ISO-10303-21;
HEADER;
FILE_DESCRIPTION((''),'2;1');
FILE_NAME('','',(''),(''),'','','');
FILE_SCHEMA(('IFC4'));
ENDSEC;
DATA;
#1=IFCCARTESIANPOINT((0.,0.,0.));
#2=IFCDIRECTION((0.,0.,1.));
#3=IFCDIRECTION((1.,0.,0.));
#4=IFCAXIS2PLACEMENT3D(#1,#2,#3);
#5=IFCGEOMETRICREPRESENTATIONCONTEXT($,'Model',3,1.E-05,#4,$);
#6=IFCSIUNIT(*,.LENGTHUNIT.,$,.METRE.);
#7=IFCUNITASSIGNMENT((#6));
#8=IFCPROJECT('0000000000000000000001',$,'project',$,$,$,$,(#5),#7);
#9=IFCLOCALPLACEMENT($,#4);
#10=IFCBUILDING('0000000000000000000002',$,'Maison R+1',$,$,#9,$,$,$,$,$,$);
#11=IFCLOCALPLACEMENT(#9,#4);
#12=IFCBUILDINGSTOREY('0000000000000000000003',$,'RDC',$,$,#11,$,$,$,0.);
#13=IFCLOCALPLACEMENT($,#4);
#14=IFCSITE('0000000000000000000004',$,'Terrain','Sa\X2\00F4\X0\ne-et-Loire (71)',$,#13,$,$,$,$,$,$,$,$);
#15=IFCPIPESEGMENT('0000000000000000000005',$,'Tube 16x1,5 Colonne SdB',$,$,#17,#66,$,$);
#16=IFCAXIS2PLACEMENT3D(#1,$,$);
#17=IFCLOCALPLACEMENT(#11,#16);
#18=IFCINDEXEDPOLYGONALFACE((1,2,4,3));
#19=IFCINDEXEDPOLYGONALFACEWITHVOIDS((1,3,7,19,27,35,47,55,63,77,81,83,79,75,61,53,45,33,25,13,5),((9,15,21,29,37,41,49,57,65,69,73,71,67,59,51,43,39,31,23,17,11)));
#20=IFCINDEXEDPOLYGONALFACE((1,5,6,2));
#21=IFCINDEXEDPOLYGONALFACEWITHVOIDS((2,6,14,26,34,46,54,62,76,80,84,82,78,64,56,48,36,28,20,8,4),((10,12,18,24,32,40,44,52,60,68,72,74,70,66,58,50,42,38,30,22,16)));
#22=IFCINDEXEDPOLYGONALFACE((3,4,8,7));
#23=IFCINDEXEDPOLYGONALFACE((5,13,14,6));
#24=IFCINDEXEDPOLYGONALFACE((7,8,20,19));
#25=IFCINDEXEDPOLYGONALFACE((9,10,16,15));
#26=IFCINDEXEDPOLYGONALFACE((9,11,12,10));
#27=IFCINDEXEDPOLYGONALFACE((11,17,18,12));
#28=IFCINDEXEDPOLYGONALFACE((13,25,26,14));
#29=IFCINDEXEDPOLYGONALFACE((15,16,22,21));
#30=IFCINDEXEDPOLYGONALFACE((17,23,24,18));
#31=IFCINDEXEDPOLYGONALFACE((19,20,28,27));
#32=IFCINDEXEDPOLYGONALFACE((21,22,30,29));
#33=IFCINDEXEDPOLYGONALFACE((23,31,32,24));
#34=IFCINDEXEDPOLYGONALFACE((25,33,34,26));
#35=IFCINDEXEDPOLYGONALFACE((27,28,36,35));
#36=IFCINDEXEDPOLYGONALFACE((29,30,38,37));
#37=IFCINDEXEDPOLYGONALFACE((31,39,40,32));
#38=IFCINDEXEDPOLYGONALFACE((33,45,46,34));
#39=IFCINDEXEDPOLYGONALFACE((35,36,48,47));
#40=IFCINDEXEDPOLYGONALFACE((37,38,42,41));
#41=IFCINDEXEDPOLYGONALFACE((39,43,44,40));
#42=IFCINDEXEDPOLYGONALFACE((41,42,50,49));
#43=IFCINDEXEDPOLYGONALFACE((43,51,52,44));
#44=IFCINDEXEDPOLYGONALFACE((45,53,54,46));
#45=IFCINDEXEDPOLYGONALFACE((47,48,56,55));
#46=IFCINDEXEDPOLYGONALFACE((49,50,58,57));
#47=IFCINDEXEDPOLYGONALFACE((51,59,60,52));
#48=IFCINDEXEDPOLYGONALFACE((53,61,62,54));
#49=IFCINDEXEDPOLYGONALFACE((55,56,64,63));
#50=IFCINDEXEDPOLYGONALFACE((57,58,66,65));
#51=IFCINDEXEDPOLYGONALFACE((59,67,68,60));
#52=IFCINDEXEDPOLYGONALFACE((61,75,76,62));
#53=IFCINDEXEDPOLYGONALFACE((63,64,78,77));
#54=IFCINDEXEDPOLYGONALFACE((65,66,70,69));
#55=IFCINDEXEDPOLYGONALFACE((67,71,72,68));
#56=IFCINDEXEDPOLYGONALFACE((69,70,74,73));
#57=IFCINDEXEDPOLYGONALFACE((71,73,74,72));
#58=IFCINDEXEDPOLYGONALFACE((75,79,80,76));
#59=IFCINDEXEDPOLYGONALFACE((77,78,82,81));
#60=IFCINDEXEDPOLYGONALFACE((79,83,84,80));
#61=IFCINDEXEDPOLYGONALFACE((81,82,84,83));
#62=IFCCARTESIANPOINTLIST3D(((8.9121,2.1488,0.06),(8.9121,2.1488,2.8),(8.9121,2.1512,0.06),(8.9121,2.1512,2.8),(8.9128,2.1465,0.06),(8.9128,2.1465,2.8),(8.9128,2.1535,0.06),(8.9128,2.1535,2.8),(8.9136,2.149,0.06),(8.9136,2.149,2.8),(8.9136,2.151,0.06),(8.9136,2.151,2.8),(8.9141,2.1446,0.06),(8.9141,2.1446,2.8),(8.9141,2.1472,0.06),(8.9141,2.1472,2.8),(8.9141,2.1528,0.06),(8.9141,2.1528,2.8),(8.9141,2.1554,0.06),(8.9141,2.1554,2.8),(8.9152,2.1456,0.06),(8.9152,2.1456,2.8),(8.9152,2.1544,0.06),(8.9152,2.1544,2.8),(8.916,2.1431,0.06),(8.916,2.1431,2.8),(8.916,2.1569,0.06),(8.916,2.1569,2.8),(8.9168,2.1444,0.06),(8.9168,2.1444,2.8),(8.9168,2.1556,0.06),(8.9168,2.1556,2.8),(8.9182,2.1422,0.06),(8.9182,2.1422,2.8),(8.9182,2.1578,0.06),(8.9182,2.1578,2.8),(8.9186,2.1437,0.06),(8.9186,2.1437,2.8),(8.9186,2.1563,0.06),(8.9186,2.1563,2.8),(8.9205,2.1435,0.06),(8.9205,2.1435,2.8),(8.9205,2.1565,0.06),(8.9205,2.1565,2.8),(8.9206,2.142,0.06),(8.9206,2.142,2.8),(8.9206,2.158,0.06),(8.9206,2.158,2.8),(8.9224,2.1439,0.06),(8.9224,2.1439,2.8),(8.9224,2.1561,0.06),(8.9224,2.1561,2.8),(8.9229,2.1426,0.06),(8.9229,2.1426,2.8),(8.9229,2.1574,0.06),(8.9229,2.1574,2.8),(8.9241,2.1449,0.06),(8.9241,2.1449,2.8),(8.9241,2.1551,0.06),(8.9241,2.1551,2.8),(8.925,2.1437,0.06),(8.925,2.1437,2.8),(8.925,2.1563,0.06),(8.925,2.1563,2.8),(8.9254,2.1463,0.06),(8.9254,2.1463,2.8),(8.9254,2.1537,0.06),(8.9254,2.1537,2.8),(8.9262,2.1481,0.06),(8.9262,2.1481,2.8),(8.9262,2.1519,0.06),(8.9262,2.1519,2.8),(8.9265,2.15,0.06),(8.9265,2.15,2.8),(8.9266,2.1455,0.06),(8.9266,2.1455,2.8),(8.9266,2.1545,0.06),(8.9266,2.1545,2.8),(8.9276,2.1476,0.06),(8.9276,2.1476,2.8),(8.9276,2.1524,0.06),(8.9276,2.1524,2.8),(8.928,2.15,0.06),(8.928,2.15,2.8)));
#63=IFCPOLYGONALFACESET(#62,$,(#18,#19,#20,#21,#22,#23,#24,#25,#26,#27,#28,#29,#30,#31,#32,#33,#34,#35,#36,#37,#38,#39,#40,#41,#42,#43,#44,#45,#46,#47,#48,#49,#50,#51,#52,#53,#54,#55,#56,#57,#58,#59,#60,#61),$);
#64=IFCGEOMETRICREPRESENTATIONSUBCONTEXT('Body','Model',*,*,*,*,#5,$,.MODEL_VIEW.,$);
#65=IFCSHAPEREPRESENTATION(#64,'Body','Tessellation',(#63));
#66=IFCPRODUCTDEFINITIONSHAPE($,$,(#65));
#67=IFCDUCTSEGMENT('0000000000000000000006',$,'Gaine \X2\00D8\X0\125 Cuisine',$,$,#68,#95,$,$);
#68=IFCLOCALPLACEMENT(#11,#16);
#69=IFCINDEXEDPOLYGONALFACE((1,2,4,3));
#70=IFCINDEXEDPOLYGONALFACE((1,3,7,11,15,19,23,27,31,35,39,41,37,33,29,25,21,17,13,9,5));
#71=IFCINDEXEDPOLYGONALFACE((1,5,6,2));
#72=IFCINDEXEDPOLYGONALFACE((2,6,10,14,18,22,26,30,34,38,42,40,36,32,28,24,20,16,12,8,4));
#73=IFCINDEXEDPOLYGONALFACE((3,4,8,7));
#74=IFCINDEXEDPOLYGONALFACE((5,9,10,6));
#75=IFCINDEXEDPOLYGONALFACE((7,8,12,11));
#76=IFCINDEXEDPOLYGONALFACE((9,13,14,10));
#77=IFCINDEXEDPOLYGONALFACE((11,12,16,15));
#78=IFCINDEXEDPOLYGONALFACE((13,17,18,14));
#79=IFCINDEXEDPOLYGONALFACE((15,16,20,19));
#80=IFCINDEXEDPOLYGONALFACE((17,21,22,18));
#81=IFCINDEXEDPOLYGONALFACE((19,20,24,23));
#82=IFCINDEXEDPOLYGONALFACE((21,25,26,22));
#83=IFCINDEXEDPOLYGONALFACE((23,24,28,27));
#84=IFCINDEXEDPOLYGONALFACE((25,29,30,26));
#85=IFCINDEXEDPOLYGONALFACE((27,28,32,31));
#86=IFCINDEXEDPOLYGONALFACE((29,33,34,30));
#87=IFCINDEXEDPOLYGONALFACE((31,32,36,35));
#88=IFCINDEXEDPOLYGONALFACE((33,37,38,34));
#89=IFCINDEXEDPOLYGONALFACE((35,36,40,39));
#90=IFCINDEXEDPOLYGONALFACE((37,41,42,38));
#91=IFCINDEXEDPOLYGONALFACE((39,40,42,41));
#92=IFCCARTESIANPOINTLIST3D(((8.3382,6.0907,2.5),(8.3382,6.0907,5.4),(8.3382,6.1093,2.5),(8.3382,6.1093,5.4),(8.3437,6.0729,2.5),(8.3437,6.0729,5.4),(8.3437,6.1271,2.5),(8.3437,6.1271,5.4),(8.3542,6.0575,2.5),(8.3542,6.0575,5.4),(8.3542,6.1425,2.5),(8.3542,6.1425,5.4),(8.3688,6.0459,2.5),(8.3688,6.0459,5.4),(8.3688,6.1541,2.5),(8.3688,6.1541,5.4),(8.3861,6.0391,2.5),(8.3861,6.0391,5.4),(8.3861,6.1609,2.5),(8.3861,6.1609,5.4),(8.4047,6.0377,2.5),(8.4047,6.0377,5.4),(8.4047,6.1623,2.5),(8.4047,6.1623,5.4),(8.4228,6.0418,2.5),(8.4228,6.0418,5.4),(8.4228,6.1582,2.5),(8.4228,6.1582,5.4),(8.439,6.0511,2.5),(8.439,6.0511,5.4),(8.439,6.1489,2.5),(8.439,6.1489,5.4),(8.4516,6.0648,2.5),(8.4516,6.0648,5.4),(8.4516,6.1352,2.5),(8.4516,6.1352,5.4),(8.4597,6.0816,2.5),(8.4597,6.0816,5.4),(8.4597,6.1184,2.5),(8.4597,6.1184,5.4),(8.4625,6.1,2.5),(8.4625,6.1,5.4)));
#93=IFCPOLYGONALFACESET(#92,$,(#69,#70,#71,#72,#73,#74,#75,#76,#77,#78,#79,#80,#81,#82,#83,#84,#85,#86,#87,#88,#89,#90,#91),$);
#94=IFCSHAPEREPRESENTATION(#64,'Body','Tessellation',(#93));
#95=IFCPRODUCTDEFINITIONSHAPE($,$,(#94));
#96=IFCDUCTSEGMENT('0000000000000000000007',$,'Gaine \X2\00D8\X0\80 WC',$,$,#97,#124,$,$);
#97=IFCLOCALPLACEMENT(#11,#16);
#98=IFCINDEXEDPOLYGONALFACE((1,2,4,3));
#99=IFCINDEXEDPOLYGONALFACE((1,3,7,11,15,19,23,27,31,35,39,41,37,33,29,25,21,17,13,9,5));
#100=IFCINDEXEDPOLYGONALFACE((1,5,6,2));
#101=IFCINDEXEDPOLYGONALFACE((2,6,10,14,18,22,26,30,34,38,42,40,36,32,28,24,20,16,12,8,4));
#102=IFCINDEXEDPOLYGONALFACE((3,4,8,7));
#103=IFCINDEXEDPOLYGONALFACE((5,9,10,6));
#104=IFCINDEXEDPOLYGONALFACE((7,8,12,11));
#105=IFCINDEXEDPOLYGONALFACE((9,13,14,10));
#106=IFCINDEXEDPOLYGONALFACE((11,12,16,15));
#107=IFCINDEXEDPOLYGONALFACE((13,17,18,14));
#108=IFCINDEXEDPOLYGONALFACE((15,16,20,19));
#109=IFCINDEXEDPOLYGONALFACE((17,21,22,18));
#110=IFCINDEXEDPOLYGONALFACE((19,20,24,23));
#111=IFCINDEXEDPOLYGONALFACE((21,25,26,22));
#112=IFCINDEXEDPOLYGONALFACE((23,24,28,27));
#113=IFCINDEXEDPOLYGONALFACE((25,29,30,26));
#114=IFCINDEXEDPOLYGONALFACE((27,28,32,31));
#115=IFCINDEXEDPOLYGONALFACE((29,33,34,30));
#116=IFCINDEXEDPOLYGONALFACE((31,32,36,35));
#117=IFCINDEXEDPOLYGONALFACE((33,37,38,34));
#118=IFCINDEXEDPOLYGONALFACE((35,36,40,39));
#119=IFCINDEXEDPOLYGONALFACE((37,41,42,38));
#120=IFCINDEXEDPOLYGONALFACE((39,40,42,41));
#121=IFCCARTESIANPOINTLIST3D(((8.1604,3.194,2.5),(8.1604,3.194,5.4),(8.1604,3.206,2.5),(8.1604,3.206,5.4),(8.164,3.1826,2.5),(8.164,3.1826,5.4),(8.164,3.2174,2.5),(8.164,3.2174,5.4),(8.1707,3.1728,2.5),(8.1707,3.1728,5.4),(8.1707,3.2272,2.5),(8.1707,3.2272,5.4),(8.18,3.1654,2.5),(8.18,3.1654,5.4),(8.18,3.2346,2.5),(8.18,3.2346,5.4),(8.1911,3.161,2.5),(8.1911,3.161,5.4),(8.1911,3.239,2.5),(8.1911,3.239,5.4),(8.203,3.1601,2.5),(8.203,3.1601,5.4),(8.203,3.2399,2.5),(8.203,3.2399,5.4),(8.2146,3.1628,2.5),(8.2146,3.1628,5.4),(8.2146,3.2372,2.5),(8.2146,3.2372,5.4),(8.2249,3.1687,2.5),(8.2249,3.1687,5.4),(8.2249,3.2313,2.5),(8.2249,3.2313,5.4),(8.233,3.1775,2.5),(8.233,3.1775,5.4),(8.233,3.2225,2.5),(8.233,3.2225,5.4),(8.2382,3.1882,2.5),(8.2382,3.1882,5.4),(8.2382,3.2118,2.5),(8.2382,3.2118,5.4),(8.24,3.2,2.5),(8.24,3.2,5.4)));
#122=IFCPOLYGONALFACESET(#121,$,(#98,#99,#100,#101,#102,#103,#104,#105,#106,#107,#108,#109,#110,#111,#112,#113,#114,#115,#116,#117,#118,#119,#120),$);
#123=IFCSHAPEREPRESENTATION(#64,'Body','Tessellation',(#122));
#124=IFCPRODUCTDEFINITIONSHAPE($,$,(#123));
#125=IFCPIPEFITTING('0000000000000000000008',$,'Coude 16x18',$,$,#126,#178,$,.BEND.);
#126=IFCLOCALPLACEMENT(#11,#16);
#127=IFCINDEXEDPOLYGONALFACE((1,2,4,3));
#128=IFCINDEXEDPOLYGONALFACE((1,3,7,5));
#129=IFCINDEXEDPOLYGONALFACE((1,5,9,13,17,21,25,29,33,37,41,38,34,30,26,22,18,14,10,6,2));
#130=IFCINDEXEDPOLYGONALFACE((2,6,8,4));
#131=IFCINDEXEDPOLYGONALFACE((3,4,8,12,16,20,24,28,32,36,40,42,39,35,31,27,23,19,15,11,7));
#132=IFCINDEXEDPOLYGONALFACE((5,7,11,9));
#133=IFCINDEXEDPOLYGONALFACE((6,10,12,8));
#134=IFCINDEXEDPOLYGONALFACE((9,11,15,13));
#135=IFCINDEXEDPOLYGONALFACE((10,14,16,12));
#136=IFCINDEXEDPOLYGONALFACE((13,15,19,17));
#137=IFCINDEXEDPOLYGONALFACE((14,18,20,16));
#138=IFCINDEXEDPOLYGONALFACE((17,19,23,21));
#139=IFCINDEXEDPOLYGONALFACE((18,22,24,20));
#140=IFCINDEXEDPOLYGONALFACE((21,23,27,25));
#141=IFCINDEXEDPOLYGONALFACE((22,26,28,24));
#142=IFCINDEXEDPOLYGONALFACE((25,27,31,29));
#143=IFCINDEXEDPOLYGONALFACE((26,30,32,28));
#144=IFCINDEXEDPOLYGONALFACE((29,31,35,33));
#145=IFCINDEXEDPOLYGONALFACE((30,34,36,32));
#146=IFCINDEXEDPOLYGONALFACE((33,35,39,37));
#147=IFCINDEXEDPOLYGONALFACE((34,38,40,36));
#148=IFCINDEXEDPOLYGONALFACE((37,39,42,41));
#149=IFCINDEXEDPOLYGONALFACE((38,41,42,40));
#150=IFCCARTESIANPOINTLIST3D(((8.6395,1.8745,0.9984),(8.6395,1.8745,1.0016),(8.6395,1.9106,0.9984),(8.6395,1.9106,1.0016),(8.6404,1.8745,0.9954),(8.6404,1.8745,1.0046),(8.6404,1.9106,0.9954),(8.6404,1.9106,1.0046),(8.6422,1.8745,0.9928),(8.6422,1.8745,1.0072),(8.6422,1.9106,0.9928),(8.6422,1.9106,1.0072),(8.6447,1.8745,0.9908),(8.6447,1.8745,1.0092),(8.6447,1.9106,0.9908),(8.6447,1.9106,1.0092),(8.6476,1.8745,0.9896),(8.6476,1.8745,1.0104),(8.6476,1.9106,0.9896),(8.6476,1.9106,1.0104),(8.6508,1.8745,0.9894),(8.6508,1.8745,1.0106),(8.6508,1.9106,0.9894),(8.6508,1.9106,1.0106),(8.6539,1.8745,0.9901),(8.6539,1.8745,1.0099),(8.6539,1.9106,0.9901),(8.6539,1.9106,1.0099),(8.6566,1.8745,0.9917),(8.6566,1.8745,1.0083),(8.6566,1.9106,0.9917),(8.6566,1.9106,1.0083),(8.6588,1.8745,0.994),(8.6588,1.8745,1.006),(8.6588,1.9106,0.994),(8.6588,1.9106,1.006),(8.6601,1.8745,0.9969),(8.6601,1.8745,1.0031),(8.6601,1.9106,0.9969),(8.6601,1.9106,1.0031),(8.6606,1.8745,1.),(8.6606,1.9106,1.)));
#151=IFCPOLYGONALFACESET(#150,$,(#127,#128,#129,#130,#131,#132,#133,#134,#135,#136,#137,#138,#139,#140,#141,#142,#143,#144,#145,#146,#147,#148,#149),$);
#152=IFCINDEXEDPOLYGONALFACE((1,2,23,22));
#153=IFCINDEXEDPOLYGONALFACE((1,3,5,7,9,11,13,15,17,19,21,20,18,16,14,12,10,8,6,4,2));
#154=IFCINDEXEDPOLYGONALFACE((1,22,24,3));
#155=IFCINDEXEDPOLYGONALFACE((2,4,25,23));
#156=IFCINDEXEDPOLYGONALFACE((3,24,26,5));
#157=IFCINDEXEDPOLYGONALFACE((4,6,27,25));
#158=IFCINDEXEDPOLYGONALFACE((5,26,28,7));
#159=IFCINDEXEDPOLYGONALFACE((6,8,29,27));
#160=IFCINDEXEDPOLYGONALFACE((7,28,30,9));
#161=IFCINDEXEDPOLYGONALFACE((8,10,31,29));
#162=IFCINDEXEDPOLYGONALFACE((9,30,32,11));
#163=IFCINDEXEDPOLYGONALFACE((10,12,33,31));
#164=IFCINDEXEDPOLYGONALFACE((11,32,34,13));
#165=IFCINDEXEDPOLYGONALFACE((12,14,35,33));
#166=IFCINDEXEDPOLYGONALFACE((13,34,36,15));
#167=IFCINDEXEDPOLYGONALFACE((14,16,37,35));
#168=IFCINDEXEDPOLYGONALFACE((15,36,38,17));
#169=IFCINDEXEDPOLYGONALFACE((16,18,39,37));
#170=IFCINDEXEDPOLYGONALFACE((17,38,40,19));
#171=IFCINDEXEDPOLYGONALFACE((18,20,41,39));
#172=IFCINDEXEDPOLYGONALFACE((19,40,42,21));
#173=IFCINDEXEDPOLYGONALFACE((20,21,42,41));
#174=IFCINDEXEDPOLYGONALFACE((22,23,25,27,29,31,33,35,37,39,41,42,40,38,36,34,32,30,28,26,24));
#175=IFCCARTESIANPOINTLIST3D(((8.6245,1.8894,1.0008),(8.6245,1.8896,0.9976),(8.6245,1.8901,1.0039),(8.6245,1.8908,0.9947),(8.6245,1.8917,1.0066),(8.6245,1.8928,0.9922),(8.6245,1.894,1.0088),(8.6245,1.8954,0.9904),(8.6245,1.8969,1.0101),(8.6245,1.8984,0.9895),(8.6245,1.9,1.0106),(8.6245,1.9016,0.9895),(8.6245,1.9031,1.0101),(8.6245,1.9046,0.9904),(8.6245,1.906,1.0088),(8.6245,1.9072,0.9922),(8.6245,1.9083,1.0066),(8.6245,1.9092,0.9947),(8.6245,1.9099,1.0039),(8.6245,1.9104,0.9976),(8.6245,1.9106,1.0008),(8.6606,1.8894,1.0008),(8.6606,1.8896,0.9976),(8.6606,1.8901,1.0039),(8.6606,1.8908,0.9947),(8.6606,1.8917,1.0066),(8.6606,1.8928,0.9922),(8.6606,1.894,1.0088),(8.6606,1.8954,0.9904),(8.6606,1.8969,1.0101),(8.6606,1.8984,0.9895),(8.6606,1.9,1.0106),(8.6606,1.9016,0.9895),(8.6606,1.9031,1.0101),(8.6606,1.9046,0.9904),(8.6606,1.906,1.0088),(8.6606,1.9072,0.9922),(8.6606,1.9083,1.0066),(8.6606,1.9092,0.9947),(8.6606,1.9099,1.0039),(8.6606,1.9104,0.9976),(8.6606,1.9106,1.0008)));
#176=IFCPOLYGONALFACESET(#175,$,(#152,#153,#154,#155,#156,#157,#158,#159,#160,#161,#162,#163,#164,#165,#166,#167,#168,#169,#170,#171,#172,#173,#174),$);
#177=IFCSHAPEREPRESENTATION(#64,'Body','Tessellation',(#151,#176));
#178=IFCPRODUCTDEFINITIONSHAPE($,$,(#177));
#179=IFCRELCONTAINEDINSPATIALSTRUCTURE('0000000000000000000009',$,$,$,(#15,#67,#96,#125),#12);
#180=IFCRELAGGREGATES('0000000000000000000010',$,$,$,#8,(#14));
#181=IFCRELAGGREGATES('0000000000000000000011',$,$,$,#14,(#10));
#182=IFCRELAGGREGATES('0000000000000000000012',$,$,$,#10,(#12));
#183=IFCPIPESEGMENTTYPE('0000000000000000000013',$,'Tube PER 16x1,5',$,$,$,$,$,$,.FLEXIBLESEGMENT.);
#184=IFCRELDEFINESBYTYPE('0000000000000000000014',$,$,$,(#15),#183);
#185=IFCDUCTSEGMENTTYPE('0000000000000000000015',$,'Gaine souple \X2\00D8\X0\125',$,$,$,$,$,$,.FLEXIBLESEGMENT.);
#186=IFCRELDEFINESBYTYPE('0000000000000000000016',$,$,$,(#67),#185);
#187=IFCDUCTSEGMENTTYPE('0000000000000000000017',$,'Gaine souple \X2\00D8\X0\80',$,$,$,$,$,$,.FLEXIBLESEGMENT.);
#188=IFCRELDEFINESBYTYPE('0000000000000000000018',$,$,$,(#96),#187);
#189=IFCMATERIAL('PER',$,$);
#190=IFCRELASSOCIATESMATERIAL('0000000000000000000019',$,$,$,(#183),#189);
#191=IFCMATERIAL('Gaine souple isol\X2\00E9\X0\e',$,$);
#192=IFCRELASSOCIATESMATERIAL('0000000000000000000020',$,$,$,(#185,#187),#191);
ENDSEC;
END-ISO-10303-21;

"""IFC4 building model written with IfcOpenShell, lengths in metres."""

from ifc_helpers import new_model, si_unit, frame, origin_with_axes, place, context, subcontext, project, spatial, circle, hollow_circle, extrude, material, type_object, element, save


model = new_model("IFC4")

# Units and contexts
model_context = context("Model", 3, precision=1e-05, world=origin_with_axes())
body_context = subcontext(model_context, "Body", "Model", "MODEL_VIEW")
ifc_project = project(units=[si_unit("LENGTHUNIT", "METRE")], contexts=[model_context])

# Site, building, storey
site_placement = place(None, origin_with_axes())
site = spatial("IfcSite", under=ifc_project, at=site_placement, Name="Terrain", Description="Saône-et-Loire (71)")
building_placement = place(None, origin_with_axes())
building = spatial("IfcBuilding", under=site, at=building_placement, Name="Maison R+1")
storey_placement = place(building_placement, origin_with_axes())
storey = spatial("IfcBuildingStorey", under=building, at=storey_placement, Name="RDC", Elevation=0.0)

# Pipe segment
ifc_material_1 = material(Name="PER")
pipe_segment_type_1 = type_object("IfcPipeSegmentType", Name="Tube PER 16x1,5", PredefinedType="FLEXIBLESEGMENT", material=ifc_material_1)
pipe_segment_1_placement = place(storey_placement, frame((8.92, 2.15, 0.06), z_axis=(0.0, 0.0, 1.0), x_axis=(1.0, 0.0, 0.0)))
element("IfcPipeSegment", 1, at=pipe_segment_1_placement, inside=storey, type_object=pipe_segment_type_1, Name="Tube 16x1,5 Colonne SdB", context=body_context, shape_type="SweptSolid", body=[
    extrude(hollow_circle(Radius=0.008, WallThickness=0.0015), origin_with_axes(), (0.0, 0.0, 1.0), 2.74),
])

# Duct segments
ifc_material_2 = material(Name="Gaine souple isolée")
duct_segment_type_1 = type_object("IfcDuctSegmentType", Name="Gaine souple Ø125", PredefinedType="FLEXIBLESEGMENT", material=ifc_material_2)
duct_segment_1_placement = place(storey_placement, frame((8.4, 6.1, 2.5), z_axis=(0.0, 0.0, 1.0), x_axis=(1.0, 0.0, 0.0)))
element("IfcDuctSegment", 2, at=duct_segment_1_placement, inside=storey, type_object=duct_segment_type_1, Name="Gaine Ø125 Cuisine", context=body_context, shape_type="SweptSolid", body=[
    extrude(circle(Radius=0.0625), origin_with_axes(), (0.0, 0.0, 1.0), 2.9),
])
duct_segment_type_2 = type_object("IfcDuctSegmentType", Name="Gaine souple Ø80", PredefinedType="FLEXIBLESEGMENT", material=ifc_material_2)
duct_segment_2_placement = place(storey_placement, frame((8.2, 3.2, 2.5), z_axis=(0.0, 0.0, 1.0), x_axis=(1.0, 0.0, 0.0)))
element("IfcDuctSegment", 3, at=duct_segment_2_placement, inside=storey, type_object=duct_segment_type_2, Name="Gaine Ø80 WC", context=body_context, shape_type="SweptSolid", body=[
    extrude(circle(Radius=0.04), origin_with_axes(), (0.0, 0.0, 1.0), 2.9),
])

# Pipe fitting
for number, where, z_axis, x_axis, name in (
    (4, (8.65, 1.9, 1.0), (0.0, 0.0, 1.0), (1.0, 0.0, 0.0), "Coude 16x18"),
):
    element("IfcPipeFitting", number, at=place(storey_placement, frame(where, z_axis=z_axis, x_axis=x_axis)), inside=storey, Name=name, PredefinedType="BEND", context=body_context, shape_type="SweptSolid", body=[
        extrude(circle(Radius=0.0106), frame((0.0, 0.0106, 0.0), z_axis=(0.0, -1.0, 0.0), x_axis=(1.0, 0.0, 0.0)), (0.0, 0.0, 1.0), 0.0361),
        extrude(circle(Radius=0.0106), frame((0.0106, 0.0, 0.0), z_axis=(-1.0, 0.0, 0.0), x_axis=(0.0, 0.0, 1.0)), (0.0, 0.0, 1.0), 0.0361),
    ])

save(model, "model.ifc")
